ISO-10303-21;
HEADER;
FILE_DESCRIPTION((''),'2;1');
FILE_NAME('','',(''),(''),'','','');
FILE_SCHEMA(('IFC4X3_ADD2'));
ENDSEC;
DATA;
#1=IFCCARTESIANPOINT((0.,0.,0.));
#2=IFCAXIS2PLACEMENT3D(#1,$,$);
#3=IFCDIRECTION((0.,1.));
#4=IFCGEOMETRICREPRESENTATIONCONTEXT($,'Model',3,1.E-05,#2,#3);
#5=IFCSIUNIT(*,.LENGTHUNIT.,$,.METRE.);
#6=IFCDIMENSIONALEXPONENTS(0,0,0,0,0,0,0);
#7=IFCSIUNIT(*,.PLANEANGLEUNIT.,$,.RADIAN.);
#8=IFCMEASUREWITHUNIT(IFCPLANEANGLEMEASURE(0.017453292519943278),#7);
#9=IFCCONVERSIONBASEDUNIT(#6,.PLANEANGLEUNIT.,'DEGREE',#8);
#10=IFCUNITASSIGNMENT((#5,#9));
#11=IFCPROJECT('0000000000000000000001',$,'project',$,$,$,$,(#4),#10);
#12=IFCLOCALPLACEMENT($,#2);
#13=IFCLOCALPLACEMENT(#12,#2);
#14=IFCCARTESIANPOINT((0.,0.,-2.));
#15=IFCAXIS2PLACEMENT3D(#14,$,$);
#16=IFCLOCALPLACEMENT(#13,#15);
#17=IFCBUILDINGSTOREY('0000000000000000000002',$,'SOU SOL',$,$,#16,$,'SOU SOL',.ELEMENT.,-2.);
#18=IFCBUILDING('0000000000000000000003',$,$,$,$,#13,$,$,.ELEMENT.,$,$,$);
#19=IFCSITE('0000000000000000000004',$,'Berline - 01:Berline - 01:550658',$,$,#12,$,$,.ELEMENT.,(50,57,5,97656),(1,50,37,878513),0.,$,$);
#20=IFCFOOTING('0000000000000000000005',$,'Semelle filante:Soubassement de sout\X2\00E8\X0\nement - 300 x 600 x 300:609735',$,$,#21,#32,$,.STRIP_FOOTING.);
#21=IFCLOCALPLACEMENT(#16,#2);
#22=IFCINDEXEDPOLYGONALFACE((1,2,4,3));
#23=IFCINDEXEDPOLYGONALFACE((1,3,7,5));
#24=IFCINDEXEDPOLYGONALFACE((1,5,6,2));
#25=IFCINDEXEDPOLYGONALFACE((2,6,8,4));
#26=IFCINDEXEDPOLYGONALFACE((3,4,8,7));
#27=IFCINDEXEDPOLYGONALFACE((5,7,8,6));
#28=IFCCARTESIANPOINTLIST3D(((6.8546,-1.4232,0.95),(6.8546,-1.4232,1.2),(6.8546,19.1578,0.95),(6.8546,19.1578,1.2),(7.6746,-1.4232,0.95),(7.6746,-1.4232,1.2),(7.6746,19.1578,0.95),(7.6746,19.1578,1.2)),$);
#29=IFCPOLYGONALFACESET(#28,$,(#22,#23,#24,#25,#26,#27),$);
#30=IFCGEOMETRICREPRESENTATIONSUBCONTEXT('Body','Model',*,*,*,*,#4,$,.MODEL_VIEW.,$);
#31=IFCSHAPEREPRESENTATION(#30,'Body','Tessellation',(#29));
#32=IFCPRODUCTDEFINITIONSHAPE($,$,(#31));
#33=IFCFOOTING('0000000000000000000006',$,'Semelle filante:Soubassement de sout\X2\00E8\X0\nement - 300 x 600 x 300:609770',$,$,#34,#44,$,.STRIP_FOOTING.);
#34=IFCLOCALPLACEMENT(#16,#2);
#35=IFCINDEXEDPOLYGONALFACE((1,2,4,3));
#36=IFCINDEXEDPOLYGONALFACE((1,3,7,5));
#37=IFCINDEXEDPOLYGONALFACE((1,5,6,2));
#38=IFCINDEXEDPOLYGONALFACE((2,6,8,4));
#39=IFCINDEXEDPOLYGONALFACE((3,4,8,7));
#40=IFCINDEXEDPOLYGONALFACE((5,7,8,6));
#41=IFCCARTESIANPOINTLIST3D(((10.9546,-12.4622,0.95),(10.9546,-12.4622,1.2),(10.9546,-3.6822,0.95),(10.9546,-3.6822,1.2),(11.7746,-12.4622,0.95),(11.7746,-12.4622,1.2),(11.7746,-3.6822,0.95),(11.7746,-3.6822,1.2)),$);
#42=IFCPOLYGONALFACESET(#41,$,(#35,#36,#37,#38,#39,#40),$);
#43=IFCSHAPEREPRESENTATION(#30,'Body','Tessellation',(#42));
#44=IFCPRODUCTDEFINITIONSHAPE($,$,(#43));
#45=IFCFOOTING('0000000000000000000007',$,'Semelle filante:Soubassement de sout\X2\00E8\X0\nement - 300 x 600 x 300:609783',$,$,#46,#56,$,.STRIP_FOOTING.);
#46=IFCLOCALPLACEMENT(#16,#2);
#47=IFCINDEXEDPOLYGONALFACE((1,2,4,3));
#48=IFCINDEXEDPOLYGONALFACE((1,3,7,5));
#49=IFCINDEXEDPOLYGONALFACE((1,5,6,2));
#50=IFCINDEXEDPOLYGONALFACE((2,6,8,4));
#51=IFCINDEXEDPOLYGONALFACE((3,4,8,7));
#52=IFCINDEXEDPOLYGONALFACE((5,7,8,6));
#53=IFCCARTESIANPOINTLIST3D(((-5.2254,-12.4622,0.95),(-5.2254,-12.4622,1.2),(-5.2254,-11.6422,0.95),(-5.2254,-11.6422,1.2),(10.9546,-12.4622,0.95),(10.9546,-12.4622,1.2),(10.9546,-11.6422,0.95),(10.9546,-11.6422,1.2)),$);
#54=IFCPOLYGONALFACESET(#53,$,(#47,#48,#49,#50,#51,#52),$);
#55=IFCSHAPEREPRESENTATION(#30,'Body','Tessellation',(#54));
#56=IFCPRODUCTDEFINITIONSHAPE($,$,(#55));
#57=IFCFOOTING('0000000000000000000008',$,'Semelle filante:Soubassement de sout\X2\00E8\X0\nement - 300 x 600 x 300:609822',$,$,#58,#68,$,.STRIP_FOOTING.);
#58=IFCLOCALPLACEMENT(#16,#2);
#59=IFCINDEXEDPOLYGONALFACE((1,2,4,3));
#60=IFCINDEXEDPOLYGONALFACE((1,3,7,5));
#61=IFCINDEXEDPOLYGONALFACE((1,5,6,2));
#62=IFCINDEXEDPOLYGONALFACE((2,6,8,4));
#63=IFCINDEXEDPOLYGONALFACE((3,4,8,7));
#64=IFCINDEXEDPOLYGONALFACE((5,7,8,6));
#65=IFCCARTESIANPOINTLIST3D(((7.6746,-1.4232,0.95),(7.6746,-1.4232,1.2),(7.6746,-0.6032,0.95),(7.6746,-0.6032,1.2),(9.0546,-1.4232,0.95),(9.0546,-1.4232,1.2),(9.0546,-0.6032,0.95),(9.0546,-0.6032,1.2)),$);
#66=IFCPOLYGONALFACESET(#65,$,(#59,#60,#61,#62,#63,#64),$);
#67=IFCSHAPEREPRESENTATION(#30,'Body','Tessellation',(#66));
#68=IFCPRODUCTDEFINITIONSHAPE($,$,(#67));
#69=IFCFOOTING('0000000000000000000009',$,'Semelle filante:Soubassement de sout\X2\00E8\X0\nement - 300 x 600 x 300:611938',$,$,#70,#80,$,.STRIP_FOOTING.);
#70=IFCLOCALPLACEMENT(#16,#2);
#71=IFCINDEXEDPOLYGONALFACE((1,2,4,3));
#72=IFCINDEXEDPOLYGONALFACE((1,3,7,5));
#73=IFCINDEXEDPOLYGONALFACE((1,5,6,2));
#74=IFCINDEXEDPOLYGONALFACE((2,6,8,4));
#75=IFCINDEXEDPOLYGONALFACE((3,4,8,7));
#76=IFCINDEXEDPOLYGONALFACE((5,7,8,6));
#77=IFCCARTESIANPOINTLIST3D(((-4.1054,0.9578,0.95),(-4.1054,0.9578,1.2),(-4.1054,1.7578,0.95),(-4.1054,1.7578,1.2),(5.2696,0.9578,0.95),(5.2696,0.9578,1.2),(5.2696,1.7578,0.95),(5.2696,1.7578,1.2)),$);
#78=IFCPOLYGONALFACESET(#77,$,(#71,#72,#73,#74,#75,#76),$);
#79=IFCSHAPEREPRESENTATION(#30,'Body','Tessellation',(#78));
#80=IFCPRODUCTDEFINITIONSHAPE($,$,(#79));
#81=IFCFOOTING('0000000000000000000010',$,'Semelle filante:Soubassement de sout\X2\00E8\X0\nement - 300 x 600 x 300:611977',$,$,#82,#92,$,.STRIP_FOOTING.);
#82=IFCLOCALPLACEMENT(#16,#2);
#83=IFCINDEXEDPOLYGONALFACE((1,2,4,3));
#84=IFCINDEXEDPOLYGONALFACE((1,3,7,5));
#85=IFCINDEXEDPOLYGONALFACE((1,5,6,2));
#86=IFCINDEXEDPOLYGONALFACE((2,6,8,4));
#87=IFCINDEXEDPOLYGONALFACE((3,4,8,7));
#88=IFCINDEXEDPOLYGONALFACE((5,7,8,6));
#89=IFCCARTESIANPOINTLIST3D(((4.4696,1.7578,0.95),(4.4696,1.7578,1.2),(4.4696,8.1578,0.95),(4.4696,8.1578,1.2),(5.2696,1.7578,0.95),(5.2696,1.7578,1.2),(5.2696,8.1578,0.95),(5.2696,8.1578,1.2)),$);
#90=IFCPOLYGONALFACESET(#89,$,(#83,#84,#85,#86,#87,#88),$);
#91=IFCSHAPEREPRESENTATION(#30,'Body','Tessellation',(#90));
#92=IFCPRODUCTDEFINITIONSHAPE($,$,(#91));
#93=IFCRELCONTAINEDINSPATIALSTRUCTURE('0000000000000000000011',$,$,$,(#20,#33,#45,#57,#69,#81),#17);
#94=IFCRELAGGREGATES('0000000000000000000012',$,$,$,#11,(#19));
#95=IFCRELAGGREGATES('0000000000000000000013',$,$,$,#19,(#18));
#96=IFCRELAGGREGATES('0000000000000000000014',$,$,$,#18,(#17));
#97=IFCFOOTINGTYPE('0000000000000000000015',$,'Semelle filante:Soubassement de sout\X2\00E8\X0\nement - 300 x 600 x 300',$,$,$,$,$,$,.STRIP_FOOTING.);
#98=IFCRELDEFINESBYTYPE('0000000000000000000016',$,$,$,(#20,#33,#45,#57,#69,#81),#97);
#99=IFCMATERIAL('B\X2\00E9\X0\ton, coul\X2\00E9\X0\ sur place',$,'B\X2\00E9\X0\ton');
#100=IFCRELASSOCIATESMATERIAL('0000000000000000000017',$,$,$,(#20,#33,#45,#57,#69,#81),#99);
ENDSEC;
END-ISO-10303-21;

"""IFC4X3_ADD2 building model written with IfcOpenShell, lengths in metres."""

from ifc_helpers import new_model, entity, si_unit, converted_unit, direction, frame, frame_2d, origin, place, context, subcontext, project, spatial, rectangle, extrude, material, type_object, element, save


model = new_model("IFC4X3_ADD2")

# Units and contexts
model_context = context("Model", 3, precision=1e-05, world=origin(), true_north=direction((0.0, 1.0)))
body_context = subcontext(model_context, "Body", "Model", "MODEL_VIEW")
ifc_project = project(units=[si_unit("LENGTHUNIT", "METRE"), converted_unit("PLANEANGLEUNIT", "DEGREE", entity("IfcPlaneAngleMeasure", 0.017453292519943278), si_unit("PLANEANGLEUNIT", "RADIAN"), dimensions=[0, 0, 0, 0, 0, 0, 0])], contexts=[model_context])

# Site, building, storey
site_placement = place(None, origin())
site = spatial("IfcSite", under=ifc_project, at=site_placement, Name="Berline - 01:Berline - 01:550658", CompositionType="ELEMENT", RefLatitude=(50, 57, 5, 97656), RefLongitude=(1, 50, 37, 878513), RefElevation=0.0)
building_placement = place(site_placement, origin())
building = spatial("IfcBuilding", under=site, at=building_placement, CompositionType="ELEMENT")
storey_placement = place(building_placement, frame((0.0, 0.0, -2.0)))
storey = spatial("IfcBuildingStorey", under=building, at=storey_placement, Name="SOU SOL", LongName="SOU SOL", CompositionType="ELEMENT", Elevation=-2.0)

# Footings
ifc_material = material(Name="Béton, coulé sur place", Category="Béton")
footing_type = type_object("IfcFootingType", Name="Semelle filante:Soubassement de soutènement - 300 x 600 x 300", PredefinedType="STRIP_FOOTING")
footing_1_placement = place(storey_placement, frame((6.8546, -1.4232, 0.95)))
element("IfcFooting", 1, at=footing_1_placement, inside=storey, type_object=footing_type, material=ifc_material, Name="Semelle filante:Soubassement de soutènement - 300 x 600 x 300:609735", PredefinedType="STRIP_FOOTING", context=body_context, shape_type="SweptSolid", body=[
    extrude(rectangle(XDim=20.581, YDim=0.82, at=frame_2d((0.0, 0.0), x_axis=(1.0, 0.0))), frame((0.41, 10.2905, 0.0), z_axis=(0.0, 0.0, 1.0), x_axis=(0.0, -1.0, 0.0)), (0.0, 0.0, 1.0), 0.25),
])
footing_2_placement = place(storey_placement, frame((10.9546, -12.4622, 0.95)))
element("IfcFooting", 2, at=footing_2_placement, inside=storey, type_object=footing_type, material=ifc_material, Name="Semelle filante:Soubassement de soutènement - 300 x 600 x 300:609770", PredefinedType="STRIP_FOOTING", context=body_context, shape_type="SweptSolid", body=[
    extrude(rectangle(XDim=8.78, YDim=0.82, at=frame_2d((0.0, 0.1367), x_axis=(1.0, 0.0))), frame((0.2733, 4.39, 0.0), z_axis=(0.0, 0.0, 1.0), x_axis=(0.0, -1.0, 0.0)), (0.0, 0.0, 1.0), 0.25),
])
footing_3_placement = place(storey_placement, frame((-5.2254, -12.4622, 0.95)))
element("IfcFooting", 3, at=footing_3_placement, inside=storey, type_object=footing_type, material=ifc_material, Name="Semelle filante:Soubassement de soutènement - 300 x 600 x 300:609783", PredefinedType="STRIP_FOOTING", context=body_context, shape_type="SweptSolid", body=[
    extrude(rectangle(XDim=16.18, YDim=0.82, at=frame_2d((0.0, 0.0), x_axis=(1.0, 0.0))), frame((8.09, 0.41, 0.0)), (0.0, 0.0, 1.0), 0.25),
])
footing_4_placement = place(storey_placement, frame((7.6746, -1.4232, 0.95)))
element("IfcFooting", 4, at=footing_4_placement, inside=storey, type_object=footing_type, material=ifc_material, Name="Semelle filante:Soubassement de soutènement - 300 x 600 x 300:609822", PredefinedType="STRIP_FOOTING", context=body_context, shape_type="SweptSolid", body=[
    extrude(rectangle(XDim=1.38, YDim=0.82, at=frame_2d((0.0, 0.0), x_axis=(1.0, 0.0))), frame((0.69, 0.41, 0.0)), (0.0, 0.0, 1.0), 0.25),
])
footing_5_placement = place(storey_placement, frame((-4.1054, 0.9578, 0.95)))
element("IfcFooting", 5, at=footing_5_placement, inside=storey, type_object=footing_type, material=ifc_material, Name="Semelle filante:Soubassement de soutènement - 300 x 600 x 300:611938", PredefinedType="STRIP_FOOTING", context=body_context, shape_type="SweptSolid", body=[
    extrude(rectangle(XDim=9.375, YDim=0.8, at=frame_2d((0.0, -0.1333), x_axis=(1.0, 0.0))), frame((4.6875, 0.5333, 0.0)), (0.0, 0.0, 1.0), 0.25),
])
footing_6_placement = place(storey_placement, frame((4.4696, 1.7578, 0.95)))
element("IfcFooting", 6, at=footing_6_placement, inside=storey, type_object=footing_type, material=ifc_material, Name="Semelle filante:Soubassement de soutènement - 300 x 600 x 300:611977", PredefinedType="STRIP_FOOTING", context=body_context, shape_type="SweptSolid", body=[
    extrude(rectangle(XDim=6.4, YDim=0.8, at=frame_2d((0.0, 0.0), x_axis=(1.0, 0.0))), frame((0.4, 3.2, 0.0), z_axis=(0.0, 0.0, 1.0), x_axis=(0.0, 1.0, 0.0)), (0.0, 0.0, 1.0), 0.25),
])

save(model, "model.ifc")
